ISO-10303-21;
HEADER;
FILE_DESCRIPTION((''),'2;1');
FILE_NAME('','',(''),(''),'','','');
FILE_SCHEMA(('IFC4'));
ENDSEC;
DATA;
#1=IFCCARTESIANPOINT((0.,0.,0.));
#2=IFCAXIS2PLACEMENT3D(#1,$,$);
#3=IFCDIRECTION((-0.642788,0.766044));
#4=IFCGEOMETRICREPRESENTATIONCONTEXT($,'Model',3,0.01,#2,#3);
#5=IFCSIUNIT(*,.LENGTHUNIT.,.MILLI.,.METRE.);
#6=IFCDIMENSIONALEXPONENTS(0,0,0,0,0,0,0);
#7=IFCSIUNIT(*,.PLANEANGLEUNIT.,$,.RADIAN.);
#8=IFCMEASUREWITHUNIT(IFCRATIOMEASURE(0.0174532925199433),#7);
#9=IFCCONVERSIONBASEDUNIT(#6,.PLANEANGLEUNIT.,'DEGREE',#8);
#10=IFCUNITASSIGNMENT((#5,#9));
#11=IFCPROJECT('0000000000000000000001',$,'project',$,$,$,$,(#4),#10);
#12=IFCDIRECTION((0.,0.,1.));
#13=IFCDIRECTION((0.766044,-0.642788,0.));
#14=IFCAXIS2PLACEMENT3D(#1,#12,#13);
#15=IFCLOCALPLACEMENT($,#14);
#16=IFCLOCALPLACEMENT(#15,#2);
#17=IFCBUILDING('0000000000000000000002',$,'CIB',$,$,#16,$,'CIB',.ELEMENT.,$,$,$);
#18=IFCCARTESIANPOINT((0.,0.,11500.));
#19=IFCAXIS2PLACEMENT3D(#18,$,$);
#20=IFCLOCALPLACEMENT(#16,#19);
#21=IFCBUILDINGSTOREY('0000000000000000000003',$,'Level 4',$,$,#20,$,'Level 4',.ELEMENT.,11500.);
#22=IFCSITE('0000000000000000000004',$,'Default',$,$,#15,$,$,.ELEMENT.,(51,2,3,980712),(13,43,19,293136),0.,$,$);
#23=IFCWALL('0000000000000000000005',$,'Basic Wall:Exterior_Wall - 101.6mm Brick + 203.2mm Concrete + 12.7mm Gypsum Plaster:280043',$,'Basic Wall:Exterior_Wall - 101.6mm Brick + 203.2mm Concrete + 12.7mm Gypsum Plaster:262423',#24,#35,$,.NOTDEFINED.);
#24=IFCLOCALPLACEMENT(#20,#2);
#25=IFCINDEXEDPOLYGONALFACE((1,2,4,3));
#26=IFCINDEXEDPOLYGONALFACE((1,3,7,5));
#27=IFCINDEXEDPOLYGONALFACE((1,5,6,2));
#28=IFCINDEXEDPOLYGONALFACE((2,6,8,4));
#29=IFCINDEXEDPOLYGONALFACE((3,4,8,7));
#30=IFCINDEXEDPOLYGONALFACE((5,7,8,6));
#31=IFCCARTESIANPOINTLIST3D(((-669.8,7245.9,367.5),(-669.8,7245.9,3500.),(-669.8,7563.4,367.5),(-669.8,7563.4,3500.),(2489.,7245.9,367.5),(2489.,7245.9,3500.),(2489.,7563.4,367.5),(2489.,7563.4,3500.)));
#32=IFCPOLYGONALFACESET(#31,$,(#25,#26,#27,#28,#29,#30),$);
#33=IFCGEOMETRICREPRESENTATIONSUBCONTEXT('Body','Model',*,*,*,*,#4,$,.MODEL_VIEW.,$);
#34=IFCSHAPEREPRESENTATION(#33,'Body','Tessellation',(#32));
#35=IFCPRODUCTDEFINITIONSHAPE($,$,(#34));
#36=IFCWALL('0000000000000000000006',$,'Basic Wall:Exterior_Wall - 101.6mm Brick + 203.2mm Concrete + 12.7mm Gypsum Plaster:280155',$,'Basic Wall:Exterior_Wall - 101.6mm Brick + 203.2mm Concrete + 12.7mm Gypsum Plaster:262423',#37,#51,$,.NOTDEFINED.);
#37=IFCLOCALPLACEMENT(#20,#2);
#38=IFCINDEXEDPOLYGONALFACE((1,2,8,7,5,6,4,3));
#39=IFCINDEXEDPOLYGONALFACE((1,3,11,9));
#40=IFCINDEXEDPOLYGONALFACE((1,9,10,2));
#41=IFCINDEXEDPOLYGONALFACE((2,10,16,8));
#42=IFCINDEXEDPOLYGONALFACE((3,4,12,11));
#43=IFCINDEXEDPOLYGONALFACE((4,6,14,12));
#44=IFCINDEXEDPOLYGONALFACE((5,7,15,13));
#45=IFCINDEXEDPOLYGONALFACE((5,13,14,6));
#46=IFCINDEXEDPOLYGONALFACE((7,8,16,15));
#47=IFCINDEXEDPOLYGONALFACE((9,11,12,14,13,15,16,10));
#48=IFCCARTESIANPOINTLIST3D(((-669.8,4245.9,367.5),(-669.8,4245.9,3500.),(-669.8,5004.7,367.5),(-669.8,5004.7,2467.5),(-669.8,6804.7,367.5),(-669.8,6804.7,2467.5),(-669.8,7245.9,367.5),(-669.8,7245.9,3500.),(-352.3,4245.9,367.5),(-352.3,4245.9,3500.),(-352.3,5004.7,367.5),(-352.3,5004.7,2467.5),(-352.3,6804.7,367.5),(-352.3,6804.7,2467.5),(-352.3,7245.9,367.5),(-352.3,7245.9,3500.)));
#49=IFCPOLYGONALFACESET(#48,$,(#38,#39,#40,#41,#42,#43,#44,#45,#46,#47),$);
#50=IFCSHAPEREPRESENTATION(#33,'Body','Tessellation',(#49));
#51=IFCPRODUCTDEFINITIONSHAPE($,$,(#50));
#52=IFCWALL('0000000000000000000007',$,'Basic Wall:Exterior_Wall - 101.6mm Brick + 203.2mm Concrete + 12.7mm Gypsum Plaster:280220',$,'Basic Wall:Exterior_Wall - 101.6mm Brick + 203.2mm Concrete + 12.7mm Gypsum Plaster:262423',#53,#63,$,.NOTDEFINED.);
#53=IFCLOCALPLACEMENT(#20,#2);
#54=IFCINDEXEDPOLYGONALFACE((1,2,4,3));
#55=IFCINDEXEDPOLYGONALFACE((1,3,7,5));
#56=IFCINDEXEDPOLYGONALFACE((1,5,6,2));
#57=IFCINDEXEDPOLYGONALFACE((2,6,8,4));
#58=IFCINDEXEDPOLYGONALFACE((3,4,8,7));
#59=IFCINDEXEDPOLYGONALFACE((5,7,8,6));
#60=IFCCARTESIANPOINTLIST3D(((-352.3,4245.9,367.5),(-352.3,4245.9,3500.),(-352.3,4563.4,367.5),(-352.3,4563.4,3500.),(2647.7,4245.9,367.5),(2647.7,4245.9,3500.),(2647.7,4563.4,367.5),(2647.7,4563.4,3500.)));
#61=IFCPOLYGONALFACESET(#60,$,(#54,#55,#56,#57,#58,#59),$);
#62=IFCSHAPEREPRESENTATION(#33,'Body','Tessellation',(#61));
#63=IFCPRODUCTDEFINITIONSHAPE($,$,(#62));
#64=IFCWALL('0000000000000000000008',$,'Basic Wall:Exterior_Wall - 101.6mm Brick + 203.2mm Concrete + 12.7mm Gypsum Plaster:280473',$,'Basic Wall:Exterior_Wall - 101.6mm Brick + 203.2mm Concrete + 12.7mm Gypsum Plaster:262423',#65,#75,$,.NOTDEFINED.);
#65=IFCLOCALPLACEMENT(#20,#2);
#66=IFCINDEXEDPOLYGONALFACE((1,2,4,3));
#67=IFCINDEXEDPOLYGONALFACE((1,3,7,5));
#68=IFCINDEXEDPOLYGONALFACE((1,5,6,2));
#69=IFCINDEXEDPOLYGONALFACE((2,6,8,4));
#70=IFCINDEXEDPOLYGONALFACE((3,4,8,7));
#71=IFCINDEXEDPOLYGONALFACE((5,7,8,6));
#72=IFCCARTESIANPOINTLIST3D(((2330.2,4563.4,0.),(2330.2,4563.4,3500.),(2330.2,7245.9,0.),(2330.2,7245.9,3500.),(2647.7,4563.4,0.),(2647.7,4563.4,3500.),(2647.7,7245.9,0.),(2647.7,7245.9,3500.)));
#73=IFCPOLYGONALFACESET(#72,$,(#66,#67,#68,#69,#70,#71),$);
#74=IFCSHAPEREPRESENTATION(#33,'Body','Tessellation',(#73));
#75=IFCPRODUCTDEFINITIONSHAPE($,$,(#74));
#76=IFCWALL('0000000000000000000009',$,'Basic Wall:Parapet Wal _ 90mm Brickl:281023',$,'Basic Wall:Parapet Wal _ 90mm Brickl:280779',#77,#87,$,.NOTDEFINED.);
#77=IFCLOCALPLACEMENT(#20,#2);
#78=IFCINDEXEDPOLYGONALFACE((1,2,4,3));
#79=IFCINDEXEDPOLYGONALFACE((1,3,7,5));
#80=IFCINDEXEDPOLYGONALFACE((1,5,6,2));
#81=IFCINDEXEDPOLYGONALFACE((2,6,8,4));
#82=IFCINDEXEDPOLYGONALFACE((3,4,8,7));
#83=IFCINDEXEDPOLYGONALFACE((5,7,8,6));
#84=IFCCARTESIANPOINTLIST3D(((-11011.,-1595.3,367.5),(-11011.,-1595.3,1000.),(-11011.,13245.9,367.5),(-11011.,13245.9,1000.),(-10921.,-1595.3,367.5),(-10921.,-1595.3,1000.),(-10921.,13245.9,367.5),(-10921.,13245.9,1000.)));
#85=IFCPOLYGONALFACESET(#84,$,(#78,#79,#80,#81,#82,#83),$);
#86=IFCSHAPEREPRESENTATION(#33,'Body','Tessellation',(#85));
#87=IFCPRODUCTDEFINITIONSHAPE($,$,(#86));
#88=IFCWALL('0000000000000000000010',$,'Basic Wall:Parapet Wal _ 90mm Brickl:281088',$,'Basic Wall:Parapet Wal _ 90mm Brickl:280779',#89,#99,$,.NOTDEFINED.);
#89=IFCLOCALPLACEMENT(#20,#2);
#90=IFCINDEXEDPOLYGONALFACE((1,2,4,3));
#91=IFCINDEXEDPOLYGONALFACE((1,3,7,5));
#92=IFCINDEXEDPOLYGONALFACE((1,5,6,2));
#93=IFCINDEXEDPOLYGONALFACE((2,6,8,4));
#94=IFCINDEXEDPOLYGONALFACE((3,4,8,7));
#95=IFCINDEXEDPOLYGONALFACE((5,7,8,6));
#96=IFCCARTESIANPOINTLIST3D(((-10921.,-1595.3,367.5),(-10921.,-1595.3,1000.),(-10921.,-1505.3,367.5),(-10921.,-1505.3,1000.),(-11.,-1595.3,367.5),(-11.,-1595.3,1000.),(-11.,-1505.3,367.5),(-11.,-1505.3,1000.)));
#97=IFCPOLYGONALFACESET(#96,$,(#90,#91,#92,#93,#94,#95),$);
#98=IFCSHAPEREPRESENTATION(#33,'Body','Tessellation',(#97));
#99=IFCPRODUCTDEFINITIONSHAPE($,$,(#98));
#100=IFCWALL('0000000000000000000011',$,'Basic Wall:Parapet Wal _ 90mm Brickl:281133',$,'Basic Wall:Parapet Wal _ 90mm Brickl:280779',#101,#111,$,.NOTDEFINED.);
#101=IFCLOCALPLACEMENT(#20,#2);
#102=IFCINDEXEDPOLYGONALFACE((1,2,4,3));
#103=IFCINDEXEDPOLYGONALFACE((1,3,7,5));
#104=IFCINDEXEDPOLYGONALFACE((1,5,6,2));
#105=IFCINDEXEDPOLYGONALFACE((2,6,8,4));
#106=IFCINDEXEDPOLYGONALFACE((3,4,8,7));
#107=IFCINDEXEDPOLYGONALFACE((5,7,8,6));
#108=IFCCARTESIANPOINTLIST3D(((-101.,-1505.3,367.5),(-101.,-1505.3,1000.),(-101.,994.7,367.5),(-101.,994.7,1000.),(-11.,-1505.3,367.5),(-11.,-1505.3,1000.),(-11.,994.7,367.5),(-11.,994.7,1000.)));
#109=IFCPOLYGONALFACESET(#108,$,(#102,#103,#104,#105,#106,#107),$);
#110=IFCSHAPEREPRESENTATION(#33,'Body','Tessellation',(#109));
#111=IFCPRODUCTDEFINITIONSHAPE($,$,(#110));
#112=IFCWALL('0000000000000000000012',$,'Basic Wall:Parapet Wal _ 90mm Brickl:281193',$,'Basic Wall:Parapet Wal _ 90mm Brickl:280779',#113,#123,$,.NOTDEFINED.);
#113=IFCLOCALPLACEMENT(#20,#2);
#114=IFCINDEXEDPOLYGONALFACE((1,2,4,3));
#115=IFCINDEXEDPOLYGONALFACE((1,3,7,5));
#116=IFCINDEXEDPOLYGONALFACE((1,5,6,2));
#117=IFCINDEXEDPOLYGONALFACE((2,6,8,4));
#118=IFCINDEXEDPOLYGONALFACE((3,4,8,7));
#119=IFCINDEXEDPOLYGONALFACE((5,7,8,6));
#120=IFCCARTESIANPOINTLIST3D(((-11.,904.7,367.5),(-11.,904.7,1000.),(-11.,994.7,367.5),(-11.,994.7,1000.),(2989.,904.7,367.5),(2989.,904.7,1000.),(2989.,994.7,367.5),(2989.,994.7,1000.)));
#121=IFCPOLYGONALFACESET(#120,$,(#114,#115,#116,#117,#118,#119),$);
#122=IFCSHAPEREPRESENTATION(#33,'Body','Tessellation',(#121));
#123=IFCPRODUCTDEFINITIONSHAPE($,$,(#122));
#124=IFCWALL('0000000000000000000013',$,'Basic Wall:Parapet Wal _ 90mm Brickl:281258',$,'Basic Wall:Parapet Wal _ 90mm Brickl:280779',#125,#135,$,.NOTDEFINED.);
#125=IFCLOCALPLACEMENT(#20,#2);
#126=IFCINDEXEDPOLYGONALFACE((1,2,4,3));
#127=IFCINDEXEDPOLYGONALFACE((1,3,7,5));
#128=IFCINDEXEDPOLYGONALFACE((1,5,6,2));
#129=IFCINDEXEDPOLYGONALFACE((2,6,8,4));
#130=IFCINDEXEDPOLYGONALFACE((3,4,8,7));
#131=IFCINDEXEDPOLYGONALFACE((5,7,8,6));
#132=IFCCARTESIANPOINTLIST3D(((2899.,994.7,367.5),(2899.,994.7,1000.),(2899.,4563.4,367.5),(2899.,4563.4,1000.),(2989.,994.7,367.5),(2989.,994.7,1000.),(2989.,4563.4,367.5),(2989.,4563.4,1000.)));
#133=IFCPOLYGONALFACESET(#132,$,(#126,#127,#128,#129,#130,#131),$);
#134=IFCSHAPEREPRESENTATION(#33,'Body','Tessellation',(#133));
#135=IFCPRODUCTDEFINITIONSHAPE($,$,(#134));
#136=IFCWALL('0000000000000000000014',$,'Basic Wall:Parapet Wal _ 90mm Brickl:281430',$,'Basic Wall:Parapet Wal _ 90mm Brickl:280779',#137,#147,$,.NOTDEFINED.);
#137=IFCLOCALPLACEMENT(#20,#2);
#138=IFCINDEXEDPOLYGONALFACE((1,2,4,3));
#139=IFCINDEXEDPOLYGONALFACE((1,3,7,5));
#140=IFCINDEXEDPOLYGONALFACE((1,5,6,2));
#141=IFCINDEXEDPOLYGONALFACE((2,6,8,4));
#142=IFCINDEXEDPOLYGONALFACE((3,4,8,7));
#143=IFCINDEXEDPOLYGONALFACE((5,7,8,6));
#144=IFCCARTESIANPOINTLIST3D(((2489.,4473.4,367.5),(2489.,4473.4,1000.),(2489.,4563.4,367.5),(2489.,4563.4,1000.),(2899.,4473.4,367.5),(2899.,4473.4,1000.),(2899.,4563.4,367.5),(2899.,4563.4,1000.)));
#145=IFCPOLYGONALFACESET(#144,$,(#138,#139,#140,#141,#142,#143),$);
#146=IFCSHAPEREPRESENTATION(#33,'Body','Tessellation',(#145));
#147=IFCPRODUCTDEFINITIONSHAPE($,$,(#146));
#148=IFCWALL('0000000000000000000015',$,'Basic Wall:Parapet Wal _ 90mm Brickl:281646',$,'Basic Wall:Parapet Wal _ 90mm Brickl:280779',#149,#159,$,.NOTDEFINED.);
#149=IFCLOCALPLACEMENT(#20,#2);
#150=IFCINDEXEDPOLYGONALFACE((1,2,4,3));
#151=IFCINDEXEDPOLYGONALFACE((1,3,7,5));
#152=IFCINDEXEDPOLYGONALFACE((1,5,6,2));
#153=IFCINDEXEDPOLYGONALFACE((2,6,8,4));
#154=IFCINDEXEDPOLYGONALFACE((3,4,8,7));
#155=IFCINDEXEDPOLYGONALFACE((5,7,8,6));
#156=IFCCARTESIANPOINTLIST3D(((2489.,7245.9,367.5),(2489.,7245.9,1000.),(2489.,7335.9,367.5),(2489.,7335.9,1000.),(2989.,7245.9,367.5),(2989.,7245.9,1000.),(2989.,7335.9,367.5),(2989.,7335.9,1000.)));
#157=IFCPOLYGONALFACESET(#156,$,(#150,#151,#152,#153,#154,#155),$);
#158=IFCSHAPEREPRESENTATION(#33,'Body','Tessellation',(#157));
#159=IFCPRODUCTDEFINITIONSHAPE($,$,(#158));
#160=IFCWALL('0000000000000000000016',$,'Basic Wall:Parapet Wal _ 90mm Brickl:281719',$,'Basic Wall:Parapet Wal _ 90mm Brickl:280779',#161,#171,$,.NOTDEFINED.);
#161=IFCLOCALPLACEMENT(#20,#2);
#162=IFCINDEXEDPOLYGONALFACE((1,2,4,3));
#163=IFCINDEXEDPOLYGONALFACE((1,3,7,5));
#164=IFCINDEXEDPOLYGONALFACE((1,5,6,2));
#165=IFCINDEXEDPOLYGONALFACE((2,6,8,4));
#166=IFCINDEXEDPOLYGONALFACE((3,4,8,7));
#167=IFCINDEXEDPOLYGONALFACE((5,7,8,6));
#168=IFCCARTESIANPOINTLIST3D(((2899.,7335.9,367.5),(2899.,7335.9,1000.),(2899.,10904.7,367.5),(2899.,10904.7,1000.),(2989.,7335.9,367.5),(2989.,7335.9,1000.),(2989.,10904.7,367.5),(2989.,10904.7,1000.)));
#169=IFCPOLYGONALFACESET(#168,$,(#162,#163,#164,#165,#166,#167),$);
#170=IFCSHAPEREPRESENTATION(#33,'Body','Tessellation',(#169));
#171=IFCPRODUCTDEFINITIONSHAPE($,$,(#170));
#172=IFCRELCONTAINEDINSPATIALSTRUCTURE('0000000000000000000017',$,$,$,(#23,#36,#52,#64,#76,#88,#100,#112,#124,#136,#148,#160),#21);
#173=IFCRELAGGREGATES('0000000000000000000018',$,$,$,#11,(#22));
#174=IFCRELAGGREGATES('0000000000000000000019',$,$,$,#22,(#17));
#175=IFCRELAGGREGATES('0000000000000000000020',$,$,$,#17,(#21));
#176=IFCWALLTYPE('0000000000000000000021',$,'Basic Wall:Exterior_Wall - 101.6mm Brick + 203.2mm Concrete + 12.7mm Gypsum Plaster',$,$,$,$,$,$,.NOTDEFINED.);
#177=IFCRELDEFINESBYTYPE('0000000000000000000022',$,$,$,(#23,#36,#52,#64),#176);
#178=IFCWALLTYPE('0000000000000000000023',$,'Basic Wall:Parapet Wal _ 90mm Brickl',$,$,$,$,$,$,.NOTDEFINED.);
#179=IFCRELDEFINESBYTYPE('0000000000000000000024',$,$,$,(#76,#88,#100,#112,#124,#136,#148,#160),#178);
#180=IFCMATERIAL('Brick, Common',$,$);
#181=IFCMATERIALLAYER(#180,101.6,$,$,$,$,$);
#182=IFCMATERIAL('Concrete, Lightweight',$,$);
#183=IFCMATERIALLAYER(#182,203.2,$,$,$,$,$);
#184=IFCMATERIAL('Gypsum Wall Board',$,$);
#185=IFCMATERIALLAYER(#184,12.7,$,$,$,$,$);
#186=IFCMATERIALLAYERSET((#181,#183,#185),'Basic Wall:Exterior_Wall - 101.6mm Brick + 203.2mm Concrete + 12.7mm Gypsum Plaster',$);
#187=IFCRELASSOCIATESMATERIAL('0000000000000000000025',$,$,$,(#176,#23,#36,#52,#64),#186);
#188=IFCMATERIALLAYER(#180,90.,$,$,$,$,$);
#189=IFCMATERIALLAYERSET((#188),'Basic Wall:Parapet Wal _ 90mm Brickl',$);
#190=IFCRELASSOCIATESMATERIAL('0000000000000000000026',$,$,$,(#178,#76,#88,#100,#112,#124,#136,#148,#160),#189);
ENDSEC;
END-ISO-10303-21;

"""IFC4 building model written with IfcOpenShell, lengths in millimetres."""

from ifc_helpers import new_model, entity, si_unit, converted_unit, direction, frame, frame_2d, origin, place, context, subcontext, project, spatial, rectangle, extrude, material, layer, layer_set, layer_usage, type_object, element, save


model = new_model("IFC4")

# Units and contexts
model_context = context("Model", 3, precision=0.01, world=origin(), true_north=direction((-0.642788, 0.766044)))
body_context = subcontext(model_context, "Body", "Model", "MODEL_VIEW")
ifc_project = project(units=[si_unit("LENGTHUNIT", "METRE", prefix="MILLI"), converted_unit("PLANEANGLEUNIT", "DEGREE", entity("IfcRatioMeasure", 0.0174532925199433), si_unit("PLANEANGLEUNIT", "RADIAN"), dimensions=[0, 0, 0, 0, 0, 0, 0])], contexts=[model_context])

# Site, building, storey
site_placement = place(None, frame((0.0, 0.0, 0.0), z_axis=(0.0, 0.0, 1.0), x_axis=(0.766044, -0.642788, 0.0)))
site = spatial("IfcSite", under=ifc_project, at=site_placement, Name="Default", CompositionType="ELEMENT", RefLatitude=(51, 2, 3, 980712), RefLongitude=(13, 43, 19, 293136), RefElevation=0.0)
building_placement = place(site_placement, origin())
building = spatial("IfcBuilding", under=site, at=building_placement, Name="CIB", LongName="CIB", CompositionType="ELEMENT")
storey_placement = place(building_placement, frame((0.0, 0.0, 11500.0)))
storey = spatial("IfcBuildingStorey", under=building, at=storey_placement, Name="Level 4", LongName="Level 4", CompositionType="ELEMENT", Elevation=11500.0)

# Wall
ifc_material_1 = material(Name="Brick, Common")
ifc_layer_1 = layer(ifc_material_1, 101.6)
ifc_material_2 = material(Name="Concrete, Lightweight")
ifc_layer_2 = layer(ifc_material_2, 203.2)
ifc_material_3 = material(Name="Gypsum Wall Board")
ifc_layer_3 = layer(ifc_material_3, 12.7)
ifc_layer_set_1 = layer_set([ifc_layer_1, ifc_layer_2, ifc_layer_3], Name="Basic Wall:Exterior_Wall - 101.6mm Brick + 203.2mm Concrete + 12.7mm Gypsum Plaster")
ifc_layer_usage_1 = layer_usage(ifc_layer_set_1, "AXIS2", "NEGATIVE", 158.8)
wall_type_1 = type_object("IfcWallType", Name="Basic Wall:Exterior_Wall - 101.6mm Brick + 203.2mm Concrete + 12.7mm Gypsum Plaster", PredefinedType="NOTDEFINED", material=ifc_layer_set_1)
wall_1_placement = place(storey_placement, frame((2647.7, 7404.7, 367.5), z_axis=(0.0, 0.0, 1.0), x_axis=(-1.0, 0.0, 0.0)))
element("IfcWall", 1, at=wall_1_placement, inside=storey, type_object=wall_type_1, material=ifc_layer_usage_1, Name="Basic Wall:Exterior_Wall - 101.6mm Brick + 203.2mm Concrete + 12.7mm Gypsum Plaster:280043", ObjectType="Basic Wall:Exterior_Wall - 101.6mm Brick + 203.2mm Concrete + 12.7mm Gypsum Plaster:262423", PredefinedType="NOTDEFINED", context=body_context, shape_type="SweptSolid", body=[
    extrude(rectangle(XDim=3158.8, YDim=317.5, at=frame_2d((1738.1, 0.0), x_axis=(-1.0, 0.0))), origin(), (0.0, 0.0, 1.0), 3132.5),
])

# Wall, opening
ifc_layer_usage_2 = layer_usage(ifc_layer_set_1, "AXIS2", "NEGATIVE", 158.8)
wall_2_placement = place(storey_placement, frame((-511.0, 7245.9, 367.5), z_axis=(0.0, 0.0, 1.0), x_axis=(0.0, -1.0, 0.0)))
wall_2 = element("IfcWall", 2, at=wall_2_placement, inside=storey, type_object=wall_type_1, material=ifc_layer_usage_2, Name="Basic Wall:Exterior_Wall - 101.6mm Brick + 203.2mm Concrete + 12.7mm Gypsum Plaster:280155", ObjectType="Basic Wall:Exterior_Wall - 101.6mm Brick + 203.2mm Concrete + 12.7mm Gypsum Plaster:262423", PredefinedType="NOTDEFINED", context=body_context, shape_type="SweptSolid", body=[
    extrude(rectangle(XDim=3000.0, YDim=317.5, at=frame_2d((1500.0, 0.0), x_axis=(-1.0, 0.0))), origin(), (0.0, 0.0, 1.0), 3132.5),
])
opening_placement = place(wall_2_placement, frame((2241.2, 158.7, 0.0)))
element("IfcOpeningElement", 3, at=opening_placement, cuts=wall_2, ObjectType="Opening", PredefinedType="OPENING", context=body_context, shape_type="SweptSolid", body=[
    extrude(rectangle(XDim=2100.0, YDim=1800.0, at=frame_2d((1050.0, 900.0), x_axis=(1.0, 0.0))), frame((0.0, 0.0, 0.0), z_axis=(0.0, -1.0, 0.0), x_axis=(0.0, 0.0, 1.0)), (0.0, 0.0, 1.0), 317.5),
])

# Walls
ifc_layer_usage_3 = layer_usage(ifc_layer_set_1, "AXIS2", "NEGATIVE", 158.8)
wall_3_placement = place(storey_placement, frame((-352.3, 4404.7, 367.5)))
element("IfcWall", 4, at=wall_3_placement, inside=storey, type_object=wall_type_1, material=ifc_layer_usage_3, Name="Basic Wall:Exterior_Wall - 101.6mm Brick + 203.2mm Concrete + 12.7mm Gypsum Plaster:280220", ObjectType="Basic Wall:Exterior_Wall - 101.6mm Brick + 203.2mm Concrete + 12.7mm Gypsum Plaster:262423", PredefinedType="NOTDEFINED", context=body_context, shape_type="SweptSolid", body=[
    extrude(rectangle(XDim=3000.0, YDim=317.5, at=frame_2d((1500.0, 0.0), x_axis=(-1.0, 0.0))), origin(), (0.0, 0.0, 1.0), 3132.5),
])
ifc_layer_usage_4 = layer_usage(ifc_layer_set_1, "AXIS2", "NEGATIVE", 158.8)
wall_4_placement = place(storey_placement, frame((2489.0, 7245.9, 0.0), z_axis=(0.0, 0.0, 1.0), x_axis=(0.0, -1.0, 0.0)))
element("IfcWall", 5, at=wall_4_placement, inside=storey, type_object=wall_type_1, material=ifc_layer_usage_4, Name="Basic Wall:Exterior_Wall - 101.6mm Brick + 203.2mm Concrete + 12.7mm Gypsum Plaster:280473", ObjectType="Basic Wall:Exterior_Wall - 101.6mm Brick + 203.2mm Concrete + 12.7mm Gypsum Plaster:262423", PredefinedType="NOTDEFINED", context=body_context, shape_type="SweptSolid", body=[
    extrude(rectangle(XDim=2682.5, YDim=317.5, at=frame_2d((1341.2, 0.0), x_axis=(-1.0, 0.0))), origin(), (0.0, 0.0, 1.0), 3500.0),
])
ifc_layer_4 = layer(ifc_material_1, 90.0)
ifc_layer_set_2 = layer_set([ifc_layer_4], Name="Basic Wall:Parapet Wal _ 90mm Brickl")
ifc_layer_usage_5 = layer_usage(ifc_layer_set_2, "AXIS2", "NEGATIVE", 45.0)
wall_type_2 = type_object("IfcWallType", Name="Basic Wall:Parapet Wal _ 90mm Brickl", PredefinedType="NOTDEFINED", material=ifc_layer_set_2)
wall_5_placement = place(storey_placement, frame((-10966.0, 13245.9, 367.5), z_axis=(0.0, 0.0, 1.0), x_axis=(0.0, -1.0, 0.0)))
element("IfcWall", 6, at=wall_5_placement, inside=storey, type_object=wall_type_2, material=ifc_layer_usage_5, Name="Basic Wall:Parapet Wal _ 90mm Brickl:281023", ObjectType="Basic Wall:Parapet Wal _ 90mm Brickl:280779", PredefinedType="NOTDEFINED", context=body_context, shape_type="SweptSolid", body=[
    extrude(rectangle(XDim=14841.2, YDim=90.0, at=frame_2d((7420.6, 0.0), x_axis=(-1.0, 0.0))), origin(), (0.0, 0.0, 1.0), 632.5),
])
ifc_layer_usage_6 = layer_usage(ifc_layer_set_2, "AXIS2", "NEGATIVE", 45.0)
wall_6_placement = place(storey_placement, frame((-10921.0, -1550.3, 367.5)))
element("IfcWall", 7, at=wall_6_placement, inside=storey, type_object=wall_type_2, material=ifc_layer_usage_6, Name="Basic Wall:Parapet Wal _ 90mm Brickl:281088", ObjectType="Basic Wall:Parapet Wal _ 90mm Brickl:280779", PredefinedType="NOTDEFINED", context=body_context, shape_type="SweptSolid", body=[
    extrude(rectangle(XDim=10910.0, YDim=90.0, at=frame_2d((5455.0, 0.0), x_axis=(-1.0, 0.0))), origin(), (0.0, 0.0, 1.0), 632.5),
])
ifc_layer_usage_7 = layer_usage(ifc_layer_set_2, "AXIS2", "NEGATIVE", 45.0)
wall_7_placement = place(storey_placement, frame((-56.0, -1505.3, 367.5), z_axis=(0.0, 0.0, 1.0), x_axis=(0.0, 1.0, 0.0)))
element("IfcWall", 8, at=wall_7_placement, inside=storey, type_object=wall_type_2, material=ifc_layer_usage_7, Name="Basic Wall:Parapet Wal _ 90mm Brickl:281133", ObjectType="Basic Wall:Parapet Wal _ 90mm Brickl:280779", PredefinedType="NOTDEFINED", context=body_context, shape_type="SweptSolid", body=[
    extrude(rectangle(XDim=2500.0, YDim=90.0, at=frame_2d((1250.0, 0.0), x_axis=(-1.0, 0.0))), origin(), (0.0, 0.0, 1.0), 632.5),
])
ifc_layer_usage_8 = layer_usage(ifc_layer_set_2, "AXIS2", "NEGATIVE", 45.0)
wall_8_placement = place(storey_placement, frame((-11.0, 949.7, 367.5)))
element("IfcWall", 9, at=wall_8_placement, inside=storey, type_object=wall_type_2, material=ifc_layer_usage_8, Name="Basic Wall:Parapet Wal _ 90mm Brickl:281193", ObjectType="Basic Wall:Parapet Wal _ 90mm Brickl:280779", PredefinedType="NOTDEFINED", context=body_context, shape_type="SweptSolid", body=[
    extrude(rectangle(XDim=3000.0, YDim=90.0, at=frame_2d((1500.0, 0.0), x_axis=(-1.0, 0.0))), origin(), (0.0, 0.0, 1.0), 632.5),
])
ifc_layer_usage_9 = layer_usage(ifc_layer_set_2, "AXIS2", "NEGATIVE", 45.0)
wall_9_placement = place(storey_placement, frame((2944.0, 994.7, 367.5), z_axis=(0.0, 0.0, 1.0), x_axis=(0.0, 1.0, 0.0)))
element("IfcWall", 10, at=wall_9_placement, inside=storey, type_object=wall_type_2, material=ifc_layer_usage_9, Name="Basic Wall:Parapet Wal _ 90mm Brickl:281258", ObjectType="Basic Wall:Parapet Wal _ 90mm Brickl:280779", PredefinedType="NOTDEFINED", context=body_context, shape_type="SweptSolid", body=[
    extrude(rectangle(XDim=3568.8, YDim=90.0, at=frame_2d((1784.4, 0.0), x_axis=(-1.0, 0.0))), origin(), (0.0, 0.0, 1.0), 632.5),
])
ifc_layer_usage_10 = layer_usage(ifc_layer_set_2, "AXIS2", "NEGATIVE", 45.0)
wall_10_placement = place(storey_placement, frame((2899.0, 4518.4, 367.5), z_axis=(0.0, 0.0, 1.0), x_axis=(-1.0, 0.0, 0.0)))
element("IfcWall", 11, at=wall_10_placement, inside=storey, type_object=wall_type_2, material=ifc_layer_usage_10, Name="Basic Wall:Parapet Wal _ 90mm Brickl:281430", ObjectType="Basic Wall:Parapet Wal _ 90mm Brickl:280779", PredefinedType="NOTDEFINED", context=body_context, shape_type="SweptSolid", body=[
    extrude(rectangle(XDim=410.0, YDim=90.0, at=frame_2d((205.0, 0.0), x_axis=(-1.0, 0.0))), origin(), (0.0, 0.0, 1.0), 632.5),
])
ifc_layer_usage_11 = layer_usage(ifc_layer_set_2, "AXIS2", "NEGATIVE", 45.0)
wall_11_placement = place(storey_placement, frame((2489.0, 7290.9, 367.5)))
element("IfcWall", 12, at=wall_11_placement, inside=storey, type_object=wall_type_2, material=ifc_layer_usage_11, Name="Basic Wall:Parapet Wal _ 90mm Brickl:281646", ObjectType="Basic Wall:Parapet Wal _ 90mm Brickl:280779", PredefinedType="NOTDEFINED", context=body_context, shape_type="SweptSolid", body=[
    extrude(rectangle(XDim=500.0, YDim=90.0, at=frame_2d((250.0, 0.0), x_axis=(-1.0, 0.0))), origin(), (0.0, 0.0, 1.0), 632.5),
])
ifc_layer_usage_12 = layer_usage(ifc_layer_set_2, "AXIS2", "NEGATIVE", 45.0)
wall_12_placement = place(storey_placement, frame((2944.0, 7335.9, 367.5), z_axis=(0.0, 0.0, 1.0), x_axis=(0.0, 1.0, 0.0)))
element("IfcWall", 13, at=wall_12_placement, inside=storey, type_object=wall_type_2, material=ifc_layer_usage_12, Name="Basic Wall:Parapet Wal _ 90mm Brickl:281719", ObjectType="Basic Wall:Parapet Wal _ 90mm Brickl:280779", PredefinedType="NOTDEFINED", context=body_context, shape_type="SweptSolid", body=[
    extrude(rectangle(XDim=3568.7, YDim=90.0, at=frame_2d((1784.4, 0.0), x_axis=(-1.0, 0.0))), origin(), (0.0, 0.0, 1.0), 632.5),
])

save(model, "model.ifc")
